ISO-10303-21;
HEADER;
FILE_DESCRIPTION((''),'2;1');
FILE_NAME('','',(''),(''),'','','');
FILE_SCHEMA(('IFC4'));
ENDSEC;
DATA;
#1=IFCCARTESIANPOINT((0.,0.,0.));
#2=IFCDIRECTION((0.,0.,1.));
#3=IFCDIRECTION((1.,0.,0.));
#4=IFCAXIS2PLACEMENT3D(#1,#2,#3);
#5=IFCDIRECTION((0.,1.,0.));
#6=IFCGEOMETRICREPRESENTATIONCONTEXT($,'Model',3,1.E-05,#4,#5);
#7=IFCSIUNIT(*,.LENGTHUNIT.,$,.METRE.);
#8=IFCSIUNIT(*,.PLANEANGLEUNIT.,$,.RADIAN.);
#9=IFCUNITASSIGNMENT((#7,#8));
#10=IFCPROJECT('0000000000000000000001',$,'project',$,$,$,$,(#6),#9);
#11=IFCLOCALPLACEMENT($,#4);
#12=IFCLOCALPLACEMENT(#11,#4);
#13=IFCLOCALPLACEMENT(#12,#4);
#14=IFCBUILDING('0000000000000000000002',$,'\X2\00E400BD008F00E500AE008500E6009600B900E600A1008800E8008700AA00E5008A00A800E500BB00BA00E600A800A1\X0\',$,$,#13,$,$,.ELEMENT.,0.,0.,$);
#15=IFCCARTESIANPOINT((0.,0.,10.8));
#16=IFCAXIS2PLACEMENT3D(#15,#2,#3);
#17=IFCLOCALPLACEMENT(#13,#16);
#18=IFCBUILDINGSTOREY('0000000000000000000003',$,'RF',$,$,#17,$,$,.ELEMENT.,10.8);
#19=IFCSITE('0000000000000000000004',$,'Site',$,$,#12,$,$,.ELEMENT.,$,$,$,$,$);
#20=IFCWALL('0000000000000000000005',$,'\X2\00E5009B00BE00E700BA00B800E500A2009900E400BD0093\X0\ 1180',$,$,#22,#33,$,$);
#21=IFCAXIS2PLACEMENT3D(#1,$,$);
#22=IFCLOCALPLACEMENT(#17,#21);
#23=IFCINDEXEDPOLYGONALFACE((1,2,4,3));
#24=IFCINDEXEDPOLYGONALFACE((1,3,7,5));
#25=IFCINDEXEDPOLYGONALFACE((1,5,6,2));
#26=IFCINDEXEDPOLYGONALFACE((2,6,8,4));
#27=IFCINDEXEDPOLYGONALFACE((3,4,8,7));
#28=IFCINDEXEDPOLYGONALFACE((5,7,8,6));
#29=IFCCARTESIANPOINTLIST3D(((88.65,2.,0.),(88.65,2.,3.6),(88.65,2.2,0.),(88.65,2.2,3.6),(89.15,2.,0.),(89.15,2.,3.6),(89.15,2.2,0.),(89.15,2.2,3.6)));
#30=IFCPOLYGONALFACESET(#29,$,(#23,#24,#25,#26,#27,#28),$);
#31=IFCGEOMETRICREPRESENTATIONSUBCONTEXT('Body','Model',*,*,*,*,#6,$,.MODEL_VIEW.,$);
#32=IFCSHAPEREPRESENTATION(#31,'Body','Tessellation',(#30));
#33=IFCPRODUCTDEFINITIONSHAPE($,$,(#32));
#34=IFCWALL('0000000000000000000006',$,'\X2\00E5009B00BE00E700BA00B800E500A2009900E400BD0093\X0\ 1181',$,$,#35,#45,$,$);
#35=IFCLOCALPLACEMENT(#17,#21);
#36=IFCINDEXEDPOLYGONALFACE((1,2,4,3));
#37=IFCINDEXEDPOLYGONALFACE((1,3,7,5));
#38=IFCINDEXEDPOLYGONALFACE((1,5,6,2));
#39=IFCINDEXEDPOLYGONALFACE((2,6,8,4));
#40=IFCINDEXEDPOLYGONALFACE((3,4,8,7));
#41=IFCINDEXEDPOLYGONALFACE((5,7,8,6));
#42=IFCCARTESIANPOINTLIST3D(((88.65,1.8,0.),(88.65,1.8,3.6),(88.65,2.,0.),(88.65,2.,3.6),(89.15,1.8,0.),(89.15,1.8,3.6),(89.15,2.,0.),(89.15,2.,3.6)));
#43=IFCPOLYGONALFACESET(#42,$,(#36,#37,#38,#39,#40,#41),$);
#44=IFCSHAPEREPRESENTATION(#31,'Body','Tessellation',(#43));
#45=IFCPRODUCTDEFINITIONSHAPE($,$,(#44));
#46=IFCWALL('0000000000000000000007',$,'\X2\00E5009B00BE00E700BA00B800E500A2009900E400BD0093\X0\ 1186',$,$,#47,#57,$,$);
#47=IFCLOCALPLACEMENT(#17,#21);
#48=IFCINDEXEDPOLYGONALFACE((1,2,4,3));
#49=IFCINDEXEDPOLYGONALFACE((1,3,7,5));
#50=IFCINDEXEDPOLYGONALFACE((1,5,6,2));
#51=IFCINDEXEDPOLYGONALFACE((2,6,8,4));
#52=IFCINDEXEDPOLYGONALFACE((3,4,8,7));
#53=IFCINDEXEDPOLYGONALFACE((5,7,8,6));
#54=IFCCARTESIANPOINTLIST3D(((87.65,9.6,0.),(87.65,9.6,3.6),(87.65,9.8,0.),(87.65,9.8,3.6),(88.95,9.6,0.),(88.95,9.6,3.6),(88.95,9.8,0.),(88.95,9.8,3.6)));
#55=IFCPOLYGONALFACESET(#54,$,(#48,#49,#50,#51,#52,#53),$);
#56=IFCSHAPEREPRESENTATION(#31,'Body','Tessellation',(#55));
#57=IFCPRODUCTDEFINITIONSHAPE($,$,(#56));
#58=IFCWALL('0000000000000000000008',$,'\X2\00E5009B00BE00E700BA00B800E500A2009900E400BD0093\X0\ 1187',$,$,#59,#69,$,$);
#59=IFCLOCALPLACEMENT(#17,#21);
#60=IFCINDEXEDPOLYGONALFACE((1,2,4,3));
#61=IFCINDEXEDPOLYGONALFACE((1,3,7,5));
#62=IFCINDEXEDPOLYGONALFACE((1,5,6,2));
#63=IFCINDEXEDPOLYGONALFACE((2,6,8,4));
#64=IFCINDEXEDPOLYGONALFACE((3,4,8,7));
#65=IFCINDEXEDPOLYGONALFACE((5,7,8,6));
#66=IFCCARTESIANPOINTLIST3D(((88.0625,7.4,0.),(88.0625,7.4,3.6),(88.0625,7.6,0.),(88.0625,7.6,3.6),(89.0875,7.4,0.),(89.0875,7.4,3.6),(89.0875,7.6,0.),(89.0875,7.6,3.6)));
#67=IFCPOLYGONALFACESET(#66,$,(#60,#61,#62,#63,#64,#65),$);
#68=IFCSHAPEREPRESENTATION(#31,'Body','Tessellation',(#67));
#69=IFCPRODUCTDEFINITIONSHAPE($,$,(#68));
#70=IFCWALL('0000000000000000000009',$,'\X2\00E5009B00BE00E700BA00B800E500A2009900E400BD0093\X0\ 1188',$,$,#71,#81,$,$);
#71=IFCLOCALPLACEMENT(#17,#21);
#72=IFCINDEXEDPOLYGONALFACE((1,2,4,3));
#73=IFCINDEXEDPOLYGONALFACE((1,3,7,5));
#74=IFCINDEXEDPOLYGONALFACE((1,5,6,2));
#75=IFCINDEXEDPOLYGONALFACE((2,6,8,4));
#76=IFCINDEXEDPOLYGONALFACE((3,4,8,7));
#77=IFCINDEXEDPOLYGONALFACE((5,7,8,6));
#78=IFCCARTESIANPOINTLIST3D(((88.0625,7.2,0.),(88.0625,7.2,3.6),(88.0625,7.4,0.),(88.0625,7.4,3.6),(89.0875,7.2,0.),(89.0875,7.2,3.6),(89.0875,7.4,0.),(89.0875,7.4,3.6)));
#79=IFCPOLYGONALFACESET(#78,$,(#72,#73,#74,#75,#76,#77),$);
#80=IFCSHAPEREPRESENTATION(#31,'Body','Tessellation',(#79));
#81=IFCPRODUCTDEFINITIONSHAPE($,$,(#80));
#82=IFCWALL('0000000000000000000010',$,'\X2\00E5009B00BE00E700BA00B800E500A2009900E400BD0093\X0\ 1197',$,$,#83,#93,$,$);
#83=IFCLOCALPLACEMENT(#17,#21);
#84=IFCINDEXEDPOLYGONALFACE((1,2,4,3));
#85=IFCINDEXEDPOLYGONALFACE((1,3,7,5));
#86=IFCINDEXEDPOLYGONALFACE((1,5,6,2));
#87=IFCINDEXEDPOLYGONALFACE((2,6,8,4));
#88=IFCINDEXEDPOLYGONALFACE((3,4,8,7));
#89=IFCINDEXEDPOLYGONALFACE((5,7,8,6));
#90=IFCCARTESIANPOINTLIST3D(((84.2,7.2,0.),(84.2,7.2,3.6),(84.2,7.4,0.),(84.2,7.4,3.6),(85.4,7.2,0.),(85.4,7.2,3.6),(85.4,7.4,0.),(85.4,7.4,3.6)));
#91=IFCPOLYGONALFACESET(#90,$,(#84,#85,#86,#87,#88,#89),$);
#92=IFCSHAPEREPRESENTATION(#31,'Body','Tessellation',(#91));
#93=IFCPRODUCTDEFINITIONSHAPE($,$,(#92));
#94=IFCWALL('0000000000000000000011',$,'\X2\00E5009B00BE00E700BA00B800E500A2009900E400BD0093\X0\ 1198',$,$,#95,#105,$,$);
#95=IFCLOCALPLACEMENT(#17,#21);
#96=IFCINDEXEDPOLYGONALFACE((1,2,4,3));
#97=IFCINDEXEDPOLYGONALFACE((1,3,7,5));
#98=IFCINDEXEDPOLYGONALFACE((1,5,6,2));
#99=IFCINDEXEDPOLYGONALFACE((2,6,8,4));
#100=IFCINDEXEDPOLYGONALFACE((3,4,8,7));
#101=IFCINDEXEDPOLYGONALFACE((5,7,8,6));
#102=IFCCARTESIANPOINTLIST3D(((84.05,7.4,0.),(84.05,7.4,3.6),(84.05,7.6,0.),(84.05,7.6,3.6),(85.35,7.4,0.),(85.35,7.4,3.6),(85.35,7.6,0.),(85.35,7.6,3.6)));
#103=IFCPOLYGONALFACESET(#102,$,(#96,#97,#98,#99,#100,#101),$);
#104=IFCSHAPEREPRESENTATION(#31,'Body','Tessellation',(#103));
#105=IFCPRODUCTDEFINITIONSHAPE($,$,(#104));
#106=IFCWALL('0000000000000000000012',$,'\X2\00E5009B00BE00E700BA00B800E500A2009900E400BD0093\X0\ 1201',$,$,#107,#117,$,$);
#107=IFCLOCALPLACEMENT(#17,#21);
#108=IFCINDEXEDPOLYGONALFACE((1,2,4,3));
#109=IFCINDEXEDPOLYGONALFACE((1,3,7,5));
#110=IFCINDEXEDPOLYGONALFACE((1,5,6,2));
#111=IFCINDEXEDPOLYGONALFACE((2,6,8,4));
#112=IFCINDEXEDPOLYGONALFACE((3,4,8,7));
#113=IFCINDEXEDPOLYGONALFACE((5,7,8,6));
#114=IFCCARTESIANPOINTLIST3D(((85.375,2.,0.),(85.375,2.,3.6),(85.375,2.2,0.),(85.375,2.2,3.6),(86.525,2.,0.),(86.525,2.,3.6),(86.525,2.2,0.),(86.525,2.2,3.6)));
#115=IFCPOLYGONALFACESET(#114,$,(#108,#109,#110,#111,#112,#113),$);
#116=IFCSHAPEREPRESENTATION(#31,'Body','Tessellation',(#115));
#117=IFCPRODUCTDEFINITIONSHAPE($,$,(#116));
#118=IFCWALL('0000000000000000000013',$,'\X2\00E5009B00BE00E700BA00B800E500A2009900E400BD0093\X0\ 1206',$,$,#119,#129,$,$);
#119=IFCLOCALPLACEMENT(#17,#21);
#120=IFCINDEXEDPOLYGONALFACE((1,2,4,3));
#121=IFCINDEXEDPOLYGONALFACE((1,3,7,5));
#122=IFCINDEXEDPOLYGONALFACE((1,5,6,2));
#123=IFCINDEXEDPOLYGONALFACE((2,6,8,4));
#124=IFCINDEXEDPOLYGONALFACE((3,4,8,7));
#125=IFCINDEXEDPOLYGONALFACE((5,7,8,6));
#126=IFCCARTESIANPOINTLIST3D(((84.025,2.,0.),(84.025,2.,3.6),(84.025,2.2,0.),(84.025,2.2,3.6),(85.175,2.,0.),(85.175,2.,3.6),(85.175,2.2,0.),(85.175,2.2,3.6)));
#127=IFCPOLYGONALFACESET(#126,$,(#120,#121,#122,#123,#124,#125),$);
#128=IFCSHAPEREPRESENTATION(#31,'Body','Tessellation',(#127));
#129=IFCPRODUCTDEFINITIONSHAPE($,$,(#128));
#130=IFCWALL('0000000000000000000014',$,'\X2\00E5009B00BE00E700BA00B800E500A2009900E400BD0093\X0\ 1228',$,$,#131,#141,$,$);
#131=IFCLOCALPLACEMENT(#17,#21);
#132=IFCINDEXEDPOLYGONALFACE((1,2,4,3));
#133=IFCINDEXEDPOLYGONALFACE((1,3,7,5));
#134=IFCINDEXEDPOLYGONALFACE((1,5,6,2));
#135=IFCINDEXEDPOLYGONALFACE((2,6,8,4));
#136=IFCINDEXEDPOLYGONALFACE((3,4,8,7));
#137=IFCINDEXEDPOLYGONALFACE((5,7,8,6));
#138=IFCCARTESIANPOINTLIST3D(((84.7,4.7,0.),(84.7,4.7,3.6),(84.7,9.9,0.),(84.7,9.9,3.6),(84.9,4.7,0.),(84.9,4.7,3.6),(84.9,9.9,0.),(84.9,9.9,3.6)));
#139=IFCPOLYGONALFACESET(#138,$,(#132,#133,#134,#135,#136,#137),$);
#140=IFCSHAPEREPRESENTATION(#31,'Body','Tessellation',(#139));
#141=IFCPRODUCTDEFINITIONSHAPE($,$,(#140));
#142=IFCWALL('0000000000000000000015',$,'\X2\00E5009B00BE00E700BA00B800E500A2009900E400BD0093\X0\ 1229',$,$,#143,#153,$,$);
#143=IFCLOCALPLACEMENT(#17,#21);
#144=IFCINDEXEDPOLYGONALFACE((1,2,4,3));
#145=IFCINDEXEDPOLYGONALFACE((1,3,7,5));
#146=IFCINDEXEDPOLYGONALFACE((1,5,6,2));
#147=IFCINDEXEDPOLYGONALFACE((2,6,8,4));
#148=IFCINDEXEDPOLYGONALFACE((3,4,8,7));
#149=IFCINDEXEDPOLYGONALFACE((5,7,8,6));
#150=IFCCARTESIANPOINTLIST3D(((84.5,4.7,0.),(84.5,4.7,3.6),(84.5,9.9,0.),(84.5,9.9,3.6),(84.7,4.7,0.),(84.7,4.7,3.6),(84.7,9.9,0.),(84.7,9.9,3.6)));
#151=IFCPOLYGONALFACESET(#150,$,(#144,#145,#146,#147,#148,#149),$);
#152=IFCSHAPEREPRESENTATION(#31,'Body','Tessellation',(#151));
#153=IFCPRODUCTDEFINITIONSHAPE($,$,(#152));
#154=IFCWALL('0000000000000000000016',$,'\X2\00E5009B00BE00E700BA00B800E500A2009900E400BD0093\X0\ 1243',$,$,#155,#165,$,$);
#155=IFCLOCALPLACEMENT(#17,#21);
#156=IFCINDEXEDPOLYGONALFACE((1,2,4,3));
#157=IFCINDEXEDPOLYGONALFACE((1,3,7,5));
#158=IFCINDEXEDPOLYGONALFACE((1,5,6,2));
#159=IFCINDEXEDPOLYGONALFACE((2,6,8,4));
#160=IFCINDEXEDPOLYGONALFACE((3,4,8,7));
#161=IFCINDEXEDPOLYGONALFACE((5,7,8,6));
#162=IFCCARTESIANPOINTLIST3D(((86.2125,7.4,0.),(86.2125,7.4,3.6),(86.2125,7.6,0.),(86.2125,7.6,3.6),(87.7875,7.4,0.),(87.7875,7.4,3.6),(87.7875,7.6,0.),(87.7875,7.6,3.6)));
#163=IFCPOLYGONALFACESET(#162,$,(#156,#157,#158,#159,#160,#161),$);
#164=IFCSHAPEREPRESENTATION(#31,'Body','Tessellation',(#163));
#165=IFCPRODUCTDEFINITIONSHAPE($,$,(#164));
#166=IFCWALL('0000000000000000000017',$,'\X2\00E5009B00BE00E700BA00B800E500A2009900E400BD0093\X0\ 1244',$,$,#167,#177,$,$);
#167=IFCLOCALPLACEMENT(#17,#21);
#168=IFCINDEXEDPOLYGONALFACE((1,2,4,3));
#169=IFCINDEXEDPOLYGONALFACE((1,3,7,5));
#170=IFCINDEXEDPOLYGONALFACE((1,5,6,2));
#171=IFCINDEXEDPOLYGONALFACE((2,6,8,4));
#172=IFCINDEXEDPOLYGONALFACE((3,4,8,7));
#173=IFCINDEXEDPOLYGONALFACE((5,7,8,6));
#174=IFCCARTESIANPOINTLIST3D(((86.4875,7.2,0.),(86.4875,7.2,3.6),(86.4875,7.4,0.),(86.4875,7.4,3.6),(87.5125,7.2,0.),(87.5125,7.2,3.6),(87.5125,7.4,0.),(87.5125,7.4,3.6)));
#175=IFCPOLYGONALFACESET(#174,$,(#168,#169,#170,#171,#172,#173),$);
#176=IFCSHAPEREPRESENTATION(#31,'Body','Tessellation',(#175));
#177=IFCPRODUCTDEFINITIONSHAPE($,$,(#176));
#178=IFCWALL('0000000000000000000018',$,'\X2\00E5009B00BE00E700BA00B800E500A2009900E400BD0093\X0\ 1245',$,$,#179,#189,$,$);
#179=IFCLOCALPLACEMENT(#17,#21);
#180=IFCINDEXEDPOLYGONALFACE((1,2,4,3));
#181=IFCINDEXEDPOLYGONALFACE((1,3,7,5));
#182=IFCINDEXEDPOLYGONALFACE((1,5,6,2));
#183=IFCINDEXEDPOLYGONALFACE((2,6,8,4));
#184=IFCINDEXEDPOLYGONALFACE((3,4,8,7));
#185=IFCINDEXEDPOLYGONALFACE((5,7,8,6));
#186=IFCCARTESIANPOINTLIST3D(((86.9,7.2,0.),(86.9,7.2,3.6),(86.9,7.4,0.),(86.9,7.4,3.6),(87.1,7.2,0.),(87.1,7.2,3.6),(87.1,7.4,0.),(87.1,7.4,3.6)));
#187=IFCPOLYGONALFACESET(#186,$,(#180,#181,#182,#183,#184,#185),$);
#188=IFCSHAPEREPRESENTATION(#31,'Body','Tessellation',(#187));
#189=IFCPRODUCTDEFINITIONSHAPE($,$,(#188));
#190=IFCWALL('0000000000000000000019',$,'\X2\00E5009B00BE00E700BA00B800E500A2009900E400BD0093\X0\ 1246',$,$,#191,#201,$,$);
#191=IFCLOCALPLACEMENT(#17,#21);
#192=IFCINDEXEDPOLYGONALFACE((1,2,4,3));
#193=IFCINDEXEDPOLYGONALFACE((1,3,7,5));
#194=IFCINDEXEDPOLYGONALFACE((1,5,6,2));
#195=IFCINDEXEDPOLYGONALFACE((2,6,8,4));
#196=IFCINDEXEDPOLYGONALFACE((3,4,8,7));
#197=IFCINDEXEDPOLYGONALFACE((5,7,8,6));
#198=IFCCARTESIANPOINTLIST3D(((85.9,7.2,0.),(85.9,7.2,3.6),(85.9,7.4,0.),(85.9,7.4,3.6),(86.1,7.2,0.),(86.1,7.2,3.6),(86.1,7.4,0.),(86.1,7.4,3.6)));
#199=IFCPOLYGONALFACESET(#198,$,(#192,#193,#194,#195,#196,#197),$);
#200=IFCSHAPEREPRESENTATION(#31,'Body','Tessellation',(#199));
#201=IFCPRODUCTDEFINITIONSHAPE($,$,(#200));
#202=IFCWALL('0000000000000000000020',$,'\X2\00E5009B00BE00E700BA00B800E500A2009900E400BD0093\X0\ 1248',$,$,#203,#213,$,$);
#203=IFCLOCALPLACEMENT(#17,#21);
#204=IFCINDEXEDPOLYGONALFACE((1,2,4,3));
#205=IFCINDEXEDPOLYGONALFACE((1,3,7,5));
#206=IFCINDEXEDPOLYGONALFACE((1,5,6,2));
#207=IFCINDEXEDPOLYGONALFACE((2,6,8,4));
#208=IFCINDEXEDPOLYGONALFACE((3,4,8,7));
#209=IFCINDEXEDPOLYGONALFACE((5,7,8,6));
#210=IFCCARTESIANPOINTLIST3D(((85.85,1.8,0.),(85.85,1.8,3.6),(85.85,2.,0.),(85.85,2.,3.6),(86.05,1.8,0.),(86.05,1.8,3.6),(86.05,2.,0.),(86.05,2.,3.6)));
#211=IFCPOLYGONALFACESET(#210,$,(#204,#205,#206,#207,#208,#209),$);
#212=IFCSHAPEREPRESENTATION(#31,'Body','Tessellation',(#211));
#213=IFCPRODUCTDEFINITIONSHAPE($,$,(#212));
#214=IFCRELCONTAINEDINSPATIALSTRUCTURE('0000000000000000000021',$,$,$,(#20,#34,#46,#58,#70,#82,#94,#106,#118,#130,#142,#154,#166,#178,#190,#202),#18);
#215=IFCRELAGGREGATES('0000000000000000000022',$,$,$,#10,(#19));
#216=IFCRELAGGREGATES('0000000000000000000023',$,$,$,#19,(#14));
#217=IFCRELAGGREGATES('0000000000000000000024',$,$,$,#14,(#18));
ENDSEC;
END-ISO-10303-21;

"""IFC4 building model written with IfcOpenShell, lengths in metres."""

from ifc_helpers import new_model, si_unit, direction, frame, frame_2d, origin_with_axes, place, context, subcontext, project, spatial, rectangle, extrude, element, save


model = new_model("IFC4")

# Units and contexts
model_context = context("Model", 3, precision=1e-05, world=origin_with_axes(), true_north=direction((0.0, 1.0, 0.0)))
body_context = subcontext(model_context, "Body", "Model", "MODEL_VIEW")
ifc_project = project(units=[si_unit("LENGTHUNIT", "METRE"), si_unit("PLANEANGLEUNIT", "RADIAN")], contexts=[model_context])

# Site, building, storey
placement = place(None, origin_with_axes())
site_placement = place(placement, origin_with_axes())
site = spatial("IfcSite", under=ifc_project, at=site_placement, Name="Site", CompositionType="ELEMENT")
building_placement = place(site_placement, origin_with_axes())
building = spatial("IfcBuilding", under=site, at=building_placement, Name="ä½\u008få®\u0085æ\u0096¹æ¡\u0088è\u0087ªå\u008a¨å»ºæ¨¡", CompositionType="ELEMENT", ElevationOfRefHeight=0.0, ElevationOfTerrain=0.0)
storey_placement = place(building_placement, frame((0.0, 0.0, 10.8), z_axis=(0.0, 0.0, 1.0), x_axis=(1.0, 0.0, 0.0)))
storey = spatial("IfcBuildingStorey", under=building, at=storey_placement, Name="RF", CompositionType="ELEMENT", Elevation=10.8)

# Walls
for number, where, z_axis, x_axis, name in (
    (1, (88.9, 2.1, 0.0), (0.0, 0.0, 1.0), (-1.0, 0.0, 0.0), "å\u009b¾çº¸å¢\u0099ä½\u0093 1180"),
    (2, (88.9, 1.9, 0.0), (0.0, 0.0, 1.0), (-1.0, 0.0, 0.0), "å\u009b¾çº¸å¢\u0099ä½\u0093 1181"),
):
    element("IfcWall", number, at=place(storey_placement, frame(where, z_axis=z_axis, x_axis=x_axis)), inside=storey, Name=name, context=body_context, shape_type="SweptSolid", body=[
        extrude(rectangle(XDim=0.5, YDim=0.2, at=frame_2d((0.0, 0.0), x_axis=(1.0, 0.0, 0.0))), frame((0.0, 0.0, 0.0), z_axis=(0.0, 0.0, 1.0)), (0.0, 0.0, 1.0), 3.6),
    ])
wall_1_placement = place(storey_placement, frame((88.3, 9.7, 0.0), z_axis=(0.0, 0.0, 1.0), x_axis=(1.0, 0.0, 0.0)))
element("IfcWall", 3, at=wall_1_placement, inside=storey, Name="å\u009b¾çº¸å¢\u0099ä½\u0093 1186", context=body_context, shape_type="SweptSolid", body=[
    extrude(rectangle(XDim=1.3, YDim=0.2, at=frame_2d((0.0, 0.0), x_axis=(1.0, 0.0, 0.0))), frame((0.0, 0.0, 0.0), z_axis=(0.0, 0.0, 1.0)), (0.0, 0.0, 1.0), 3.6),
])
for number, where, z_axis, x_axis, name in (
    (4, (88.575, 7.5, 0.0), (0.0, 0.0, 1.0), (1.0, 0.0, 0.0), "å\u009b¾çº¸å¢\u0099ä½\u0093 1187"),
    (5, (88.575, 7.3, 0.0), (0.0, 0.0, 1.0), (1.0, 0.0, 0.0), "å\u009b¾çº¸å¢\u0099ä½\u0093 1188"),
):
    element("IfcWall", number, at=place(storey_placement, frame(where, z_axis=z_axis, x_axis=x_axis)), inside=storey, Name=name, context=body_context, shape_type="SweptSolid", body=[
        extrude(rectangle(XDim=1.025, YDim=0.2, at=frame_2d((0.0, 0.0), x_axis=(1.0, 0.0, 0.0))), frame((0.0, 0.0, 0.0), z_axis=(0.0, 0.0, 1.0)), (0.0, 0.0, 1.0), 3.6),
    ])
wall_2_placement = place(storey_placement, frame((84.8, 7.3, 0.0), z_axis=(0.0, 0.0, 1.0), x_axis=(1.0, 0.0, 0.0)))
element("IfcWall", 6, at=wall_2_placement, inside=storey, Name="å\u009b¾çº¸å¢\u0099ä½\u0093 1197", context=body_context, shape_type="SweptSolid", body=[
    extrude(rectangle(XDim=1.2, YDim=0.2, at=frame_2d((0.0, 0.0), x_axis=(1.0, 0.0, 0.0))), frame((0.0, 0.0, 0.0), z_axis=(0.0, 0.0, 1.0)), (0.0, 0.0, 1.0), 3.6),
])
wall_3_placement = place(storey_placement, frame((84.7, 7.5, 0.0), z_axis=(0.0, 0.0, 1.0), x_axis=(1.0, 0.0, 0.0)))
element("IfcWall", 7, at=wall_3_placement, inside=storey, Name="å\u009b¾çº¸å¢\u0099ä½\u0093 1198", context=body_context, shape_type="SweptSolid", body=[
    extrude(rectangle(XDim=1.3, YDim=0.2, at=frame_2d((0.0, 0.0), x_axis=(1.0, 0.0, 0.0))), frame((0.0, 0.0, 0.0), z_axis=(0.0, 0.0, 1.0)), (0.0, 0.0, 1.0), 3.6),
])
for number, where, z_axis, x_axis, name in (
    (8, (85.95, 2.1, 0.0), (0.0, 0.0, 1.0), (-1.0, 0.0, 0.0), "å\u009b¾çº¸å¢\u0099ä½\u0093 1201"),
    (9, (84.6, 2.1, 0.0), (0.0, 0.0, 1.0), (-1.0, 0.0, 0.0), "å\u009b¾çº¸å¢\u0099ä½\u0093 1206"),
):
    element("IfcWall", number, at=place(storey_placement, frame(where, z_axis=z_axis, x_axis=x_axis)), inside=storey, Name=name, context=body_context, shape_type="SweptSolid", body=[
        extrude(rectangle(XDim=1.15, YDim=0.2, at=frame_2d((0.0, 0.0), x_axis=(1.0, 0.0, 0.0))), frame((0.0, 0.0, 0.0), z_axis=(0.0, 0.0, 1.0)), (0.0, 0.0, 1.0), 3.6),
    ])
for number, where, z_axis, x_axis, name in (
    (10, (84.8, 7.3, 0.0), (0.0, 0.0, 1.0), (0.0, -1.0, 0.0), "å\u009b¾çº¸å¢\u0099ä½\u0093 1228"),
    (11, (84.6, 7.3, 0.0), (0.0, 0.0, 1.0), (0.0, -1.0, 0.0), "å\u009b¾çº¸å¢\u0099ä½\u0093 1229"),
):
    element("IfcWall", number, at=place(storey_placement, frame(where, z_axis=z_axis, x_axis=x_axis)), inside=storey, Name=name, context=body_context, shape_type="SweptSolid", body=[
        extrude(rectangle(XDim=5.2, YDim=0.2, at=frame_2d((0.0, 0.0), x_axis=(1.0, 0.0, 0.0))), frame((0.0, 0.0, 0.0), z_axis=(0.0, 0.0, 1.0)), (0.0, 0.0, 1.0), 3.6),
    ])
wall_4_placement = place(storey_placement, frame((87.0, 7.5, 0.0), z_axis=(0.0, 0.0, 1.0), x_axis=(1.0, 0.0, 0.0)))
element("IfcWall", 12, at=wall_4_placement, inside=storey, Name="å\u009b¾çº¸å¢\u0099ä½\u0093 1243", context=body_context, shape_type="SweptSolid", body=[
    extrude(rectangle(XDim=1.575, YDim=0.2, at=frame_2d((0.0, 0.0), x_axis=(1.0, 0.0, 0.0))), frame((0.0, 0.0, 0.0), z_axis=(0.0, 0.0, 1.0)), (0.0, 0.0, 1.0), 3.6),
])
wall_5_placement = place(storey_placement, frame((87.0, 7.3, 0.0), z_axis=(0.0, 0.0, 1.0), x_axis=(1.0, 0.0, 0.0)))
element("IfcWall", 13, at=wall_5_placement, inside=storey, Name="å\u009b¾çº¸å¢\u0099ä½\u0093 1244", context=body_context, shape_type="SweptSolid", body=[
    extrude(rectangle(XDim=1.025, YDim=0.2, at=frame_2d((0.0, 0.0), x_axis=(1.0, 0.0, 0.0))), frame((0.0, 0.0, 0.0), z_axis=(0.0, 0.0, 1.0)), (0.0, 0.0, 1.0), 3.6),
])
for number, where, z_axis, x_axis, name in (
    (14, (87.0, 7.3, 0.0), (0.0, 0.0, 1.0), (0.0, 1.0, 0.0), "å\u009b¾çº¸å¢\u0099ä½\u0093 1245"),
    (15, (86.0, 7.3, 0.0), (0.0, 0.0, 1.0), (0.0, 1.0, 0.0), "å\u009b¾çº¸å¢\u0099ä½\u0093 1246"),
    (16, (85.95, 1.9, 0.0), (0.0, 0.0, 1.0), (0.0, 1.0, 0.0), "å\u009b¾çº¸å¢\u0099ä½\u0093 1248"),
):
    element("IfcWall", number, at=place(storey_placement, frame(where, z_axis=z_axis, x_axis=x_axis)), inside=storey, Name=name, context=body_context, shape_type="SweptSolid", body=[
        extrude(rectangle(XDim=0.2, YDim=0.2, at=frame_2d((0.0, 0.0), x_axis=(1.0, 0.0, 0.0))), frame((0.0, 0.0, 0.0), z_axis=(0.0, 0.0, 1.0)), (0.0, 0.0, 1.0), 3.6),
    ])

save(model, "model.ifc")
